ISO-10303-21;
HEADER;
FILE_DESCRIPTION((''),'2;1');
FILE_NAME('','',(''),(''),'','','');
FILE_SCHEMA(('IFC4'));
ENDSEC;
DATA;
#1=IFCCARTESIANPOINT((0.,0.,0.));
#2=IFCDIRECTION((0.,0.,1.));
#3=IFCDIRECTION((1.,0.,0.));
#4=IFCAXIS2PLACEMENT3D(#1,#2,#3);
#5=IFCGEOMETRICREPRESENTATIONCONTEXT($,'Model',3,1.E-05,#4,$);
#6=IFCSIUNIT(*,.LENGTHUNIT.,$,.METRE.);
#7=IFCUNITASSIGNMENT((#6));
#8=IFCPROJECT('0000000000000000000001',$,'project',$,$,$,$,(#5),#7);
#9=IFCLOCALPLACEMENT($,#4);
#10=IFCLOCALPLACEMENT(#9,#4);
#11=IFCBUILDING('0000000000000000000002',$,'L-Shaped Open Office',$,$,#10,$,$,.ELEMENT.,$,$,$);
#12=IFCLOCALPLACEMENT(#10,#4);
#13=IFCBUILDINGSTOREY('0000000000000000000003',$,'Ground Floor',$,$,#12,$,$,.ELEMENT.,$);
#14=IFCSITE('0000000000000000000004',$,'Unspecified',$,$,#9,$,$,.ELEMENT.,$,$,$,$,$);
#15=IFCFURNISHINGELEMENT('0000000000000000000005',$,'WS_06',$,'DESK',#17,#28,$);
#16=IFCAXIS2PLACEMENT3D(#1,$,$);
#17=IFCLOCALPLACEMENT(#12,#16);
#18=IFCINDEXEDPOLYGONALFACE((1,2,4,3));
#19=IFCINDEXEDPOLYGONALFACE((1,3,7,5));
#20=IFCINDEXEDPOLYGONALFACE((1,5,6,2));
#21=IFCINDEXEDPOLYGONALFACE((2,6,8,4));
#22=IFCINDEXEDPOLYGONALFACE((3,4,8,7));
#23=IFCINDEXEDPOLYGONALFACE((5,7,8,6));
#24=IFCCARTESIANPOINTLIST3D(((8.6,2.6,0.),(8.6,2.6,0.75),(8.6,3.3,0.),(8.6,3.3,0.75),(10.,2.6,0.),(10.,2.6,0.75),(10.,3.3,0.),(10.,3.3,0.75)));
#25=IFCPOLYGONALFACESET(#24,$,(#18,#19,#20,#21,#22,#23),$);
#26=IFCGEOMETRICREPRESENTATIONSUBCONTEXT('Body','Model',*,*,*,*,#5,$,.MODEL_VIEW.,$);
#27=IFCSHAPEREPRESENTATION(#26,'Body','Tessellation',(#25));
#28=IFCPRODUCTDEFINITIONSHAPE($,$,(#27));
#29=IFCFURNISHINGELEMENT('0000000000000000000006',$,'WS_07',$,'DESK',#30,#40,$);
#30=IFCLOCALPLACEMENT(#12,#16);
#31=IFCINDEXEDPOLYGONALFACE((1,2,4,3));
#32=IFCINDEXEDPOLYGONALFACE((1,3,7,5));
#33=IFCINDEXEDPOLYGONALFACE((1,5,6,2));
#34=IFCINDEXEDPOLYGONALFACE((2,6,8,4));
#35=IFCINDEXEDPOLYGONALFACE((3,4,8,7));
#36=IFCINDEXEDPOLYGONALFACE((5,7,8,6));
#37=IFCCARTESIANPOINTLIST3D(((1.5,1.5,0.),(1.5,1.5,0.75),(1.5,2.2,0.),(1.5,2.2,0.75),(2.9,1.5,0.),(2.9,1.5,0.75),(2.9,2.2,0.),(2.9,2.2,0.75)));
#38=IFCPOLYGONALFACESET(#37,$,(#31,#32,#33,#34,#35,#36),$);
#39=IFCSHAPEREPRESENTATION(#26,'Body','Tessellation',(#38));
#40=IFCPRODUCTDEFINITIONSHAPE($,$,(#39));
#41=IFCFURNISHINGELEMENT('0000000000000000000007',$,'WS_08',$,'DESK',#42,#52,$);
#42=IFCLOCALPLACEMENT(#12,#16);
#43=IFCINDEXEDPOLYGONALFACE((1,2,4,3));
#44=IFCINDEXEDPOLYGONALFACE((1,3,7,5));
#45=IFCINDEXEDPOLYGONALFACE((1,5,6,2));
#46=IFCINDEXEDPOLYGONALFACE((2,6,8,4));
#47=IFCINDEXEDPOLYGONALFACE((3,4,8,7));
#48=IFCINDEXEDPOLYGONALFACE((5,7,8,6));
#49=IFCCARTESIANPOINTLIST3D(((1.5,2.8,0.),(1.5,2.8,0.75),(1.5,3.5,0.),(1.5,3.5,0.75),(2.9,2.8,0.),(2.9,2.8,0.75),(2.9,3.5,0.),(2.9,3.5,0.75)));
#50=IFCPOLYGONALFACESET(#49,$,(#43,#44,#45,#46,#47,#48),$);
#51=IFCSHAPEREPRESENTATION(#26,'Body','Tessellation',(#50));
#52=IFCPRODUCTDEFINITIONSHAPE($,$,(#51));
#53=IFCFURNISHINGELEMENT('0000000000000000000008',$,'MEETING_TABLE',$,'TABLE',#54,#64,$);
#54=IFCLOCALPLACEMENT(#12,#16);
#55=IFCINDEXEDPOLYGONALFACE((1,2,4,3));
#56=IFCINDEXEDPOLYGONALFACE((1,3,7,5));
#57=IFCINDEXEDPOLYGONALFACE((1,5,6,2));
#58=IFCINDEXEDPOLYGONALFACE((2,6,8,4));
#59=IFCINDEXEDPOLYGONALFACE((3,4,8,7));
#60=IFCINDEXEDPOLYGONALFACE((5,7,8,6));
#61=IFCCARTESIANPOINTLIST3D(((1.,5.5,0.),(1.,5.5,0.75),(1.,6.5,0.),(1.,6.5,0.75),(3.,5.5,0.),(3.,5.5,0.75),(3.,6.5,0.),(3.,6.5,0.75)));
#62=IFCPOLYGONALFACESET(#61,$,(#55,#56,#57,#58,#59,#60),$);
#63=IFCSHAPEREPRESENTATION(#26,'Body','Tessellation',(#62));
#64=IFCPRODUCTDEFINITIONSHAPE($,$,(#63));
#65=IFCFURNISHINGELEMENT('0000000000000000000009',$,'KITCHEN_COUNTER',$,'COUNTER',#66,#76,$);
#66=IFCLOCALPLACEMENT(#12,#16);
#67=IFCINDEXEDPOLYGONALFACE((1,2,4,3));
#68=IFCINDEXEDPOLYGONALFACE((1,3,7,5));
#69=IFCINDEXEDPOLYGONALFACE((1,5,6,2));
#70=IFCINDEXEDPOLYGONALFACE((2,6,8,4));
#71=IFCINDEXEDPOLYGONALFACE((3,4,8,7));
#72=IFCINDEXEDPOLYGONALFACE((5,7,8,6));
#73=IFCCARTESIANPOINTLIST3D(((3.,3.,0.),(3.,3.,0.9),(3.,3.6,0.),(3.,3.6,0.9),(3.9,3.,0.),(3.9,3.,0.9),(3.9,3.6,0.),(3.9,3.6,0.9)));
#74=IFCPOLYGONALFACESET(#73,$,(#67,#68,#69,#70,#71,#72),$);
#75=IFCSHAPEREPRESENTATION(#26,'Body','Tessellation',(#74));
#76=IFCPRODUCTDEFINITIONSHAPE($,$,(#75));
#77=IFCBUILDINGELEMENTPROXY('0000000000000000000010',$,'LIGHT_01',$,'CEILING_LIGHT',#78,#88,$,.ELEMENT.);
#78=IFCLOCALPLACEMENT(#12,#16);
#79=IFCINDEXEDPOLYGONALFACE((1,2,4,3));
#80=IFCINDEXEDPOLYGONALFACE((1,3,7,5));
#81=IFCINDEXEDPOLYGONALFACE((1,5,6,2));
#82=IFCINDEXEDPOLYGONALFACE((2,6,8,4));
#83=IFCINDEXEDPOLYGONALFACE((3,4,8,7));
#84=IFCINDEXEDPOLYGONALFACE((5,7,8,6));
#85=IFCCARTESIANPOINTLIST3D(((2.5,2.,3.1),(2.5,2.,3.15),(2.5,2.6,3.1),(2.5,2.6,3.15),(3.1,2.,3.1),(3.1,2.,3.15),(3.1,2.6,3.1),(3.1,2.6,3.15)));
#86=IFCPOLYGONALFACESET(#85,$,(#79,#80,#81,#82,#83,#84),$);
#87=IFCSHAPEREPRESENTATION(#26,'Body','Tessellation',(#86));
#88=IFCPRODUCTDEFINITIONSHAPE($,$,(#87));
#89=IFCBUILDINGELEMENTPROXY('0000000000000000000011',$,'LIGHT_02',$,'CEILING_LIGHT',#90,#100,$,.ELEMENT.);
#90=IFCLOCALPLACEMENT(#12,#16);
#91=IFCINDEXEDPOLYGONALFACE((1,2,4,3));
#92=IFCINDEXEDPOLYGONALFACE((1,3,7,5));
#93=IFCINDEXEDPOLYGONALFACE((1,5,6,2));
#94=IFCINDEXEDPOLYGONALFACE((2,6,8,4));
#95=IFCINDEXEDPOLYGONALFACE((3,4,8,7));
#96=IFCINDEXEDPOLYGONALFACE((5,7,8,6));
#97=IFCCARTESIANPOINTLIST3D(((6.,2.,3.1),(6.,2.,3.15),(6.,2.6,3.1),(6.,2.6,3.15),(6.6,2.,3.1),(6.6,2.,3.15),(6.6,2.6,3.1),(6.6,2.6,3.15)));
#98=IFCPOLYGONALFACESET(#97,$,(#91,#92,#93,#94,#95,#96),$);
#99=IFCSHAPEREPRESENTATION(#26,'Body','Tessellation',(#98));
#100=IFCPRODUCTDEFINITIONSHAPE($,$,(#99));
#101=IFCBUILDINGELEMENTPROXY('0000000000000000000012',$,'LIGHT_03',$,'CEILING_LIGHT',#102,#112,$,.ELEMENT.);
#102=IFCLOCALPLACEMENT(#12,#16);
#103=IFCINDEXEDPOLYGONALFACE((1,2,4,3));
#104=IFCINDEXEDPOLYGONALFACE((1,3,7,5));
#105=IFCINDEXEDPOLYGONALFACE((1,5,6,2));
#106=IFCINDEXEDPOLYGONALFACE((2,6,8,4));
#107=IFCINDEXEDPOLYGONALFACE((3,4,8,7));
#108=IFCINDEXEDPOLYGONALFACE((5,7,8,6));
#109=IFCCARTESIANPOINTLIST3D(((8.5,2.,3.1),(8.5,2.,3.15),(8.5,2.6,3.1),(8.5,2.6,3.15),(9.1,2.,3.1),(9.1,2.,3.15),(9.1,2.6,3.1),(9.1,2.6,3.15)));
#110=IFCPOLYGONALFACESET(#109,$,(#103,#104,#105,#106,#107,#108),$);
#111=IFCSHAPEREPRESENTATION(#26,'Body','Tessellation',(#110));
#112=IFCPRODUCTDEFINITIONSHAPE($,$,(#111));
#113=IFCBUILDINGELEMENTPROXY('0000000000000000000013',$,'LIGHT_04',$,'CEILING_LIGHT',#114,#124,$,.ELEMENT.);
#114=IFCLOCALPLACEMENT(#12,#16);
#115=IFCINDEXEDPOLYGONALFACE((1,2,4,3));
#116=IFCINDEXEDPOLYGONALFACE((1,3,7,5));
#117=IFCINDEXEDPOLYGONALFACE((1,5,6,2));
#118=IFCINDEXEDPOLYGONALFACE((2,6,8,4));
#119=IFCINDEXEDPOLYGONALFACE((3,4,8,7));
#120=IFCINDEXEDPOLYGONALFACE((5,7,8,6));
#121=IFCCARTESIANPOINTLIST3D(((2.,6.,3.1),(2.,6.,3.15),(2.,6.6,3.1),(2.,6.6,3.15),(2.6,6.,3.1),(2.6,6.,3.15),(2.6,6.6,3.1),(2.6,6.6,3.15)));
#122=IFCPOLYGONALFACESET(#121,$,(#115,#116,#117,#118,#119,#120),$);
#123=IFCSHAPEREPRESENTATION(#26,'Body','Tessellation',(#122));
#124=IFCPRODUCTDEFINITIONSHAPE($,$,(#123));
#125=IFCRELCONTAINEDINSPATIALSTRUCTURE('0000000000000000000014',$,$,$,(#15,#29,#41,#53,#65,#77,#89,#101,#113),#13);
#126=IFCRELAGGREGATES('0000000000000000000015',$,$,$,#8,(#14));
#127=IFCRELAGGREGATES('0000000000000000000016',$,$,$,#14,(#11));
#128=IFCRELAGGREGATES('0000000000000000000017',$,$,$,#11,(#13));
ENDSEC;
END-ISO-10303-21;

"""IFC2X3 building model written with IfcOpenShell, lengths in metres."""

from ifc_helpers import new_model, si_unit, frame, frame_2d, origin, origin_with_axes, place, context, subcontext, project, spatial, rectangle, extrude, element, save


model = new_model("IFC2X3")

# Units and contexts
model_context = context("Model", 3, precision=1e-05, world=origin_with_axes())
body_context = subcontext(model_context, "Body", "Model", "MODEL_VIEW")
ifc_project = project(units=[si_unit("LENGTHUNIT", "METRE")], contexts=[model_context])

# Site, building, storey
site_placement = place(None, origin_with_axes())
site = spatial("IfcSite", under=ifc_project, at=site_placement, Name="Unspecified", CompositionType="ELEMENT")
building_placement = place(site_placement, origin_with_axes())
building = spatial("IfcBuilding", under=site, at=building_placement, Name="L-Shaped Open Office", CompositionType="ELEMENT")
storey_placement = place(building_placement, origin_with_axes())
storey = spatial("IfcBuildingStorey", under=building, at=storey_placement, Name="Ground Floor", CompositionType="ELEMENT")

# Furnishing elements
for number, where, z_axis, x_axis, name in (
    (1, (8.6, 2.6, 0.0), (0.0, 0.0, 1.0), (1.0, 0.0, 0.0), "WS_06"),
    (2, (1.5, 1.5, 0.0), (0.0, 0.0, 1.0), (1.0, 0.0, 0.0), "WS_07"),
    (3, (1.5, 2.8, 0.0), (0.0, 0.0, 1.0), (1.0, 0.0, 0.0), "WS_08"),
):
    element("IfcFurnishingElement", number, at=place(storey_placement, frame(where, z_axis=z_axis, x_axis=x_axis)), inside=storey, Name=name, ObjectType="DESK", context=body_context, shape_type="SweptSolid", body=[
        extrude(rectangle(XDim=1.4, YDim=0.7, at=frame_2d((0.7, 0.35))), origin(), (0.0, 0.0, 1.0), 0.75),
    ])
furnishing_1_placement = place(storey_placement, frame((1.0, 5.5, 0.0), z_axis=(0.0, 0.0, 1.0), x_axis=(1.0, 0.0, 0.0)))
element("IfcFurnishingElement", 4, at=furnishing_1_placement, inside=storey, Name="MEETING_TABLE", ObjectType="TABLE", context=body_context, shape_type="SweptSolid", body=[
    extrude(rectangle(XDim=2.0, YDim=1.0, at=frame_2d((1.0, 0.5))), origin(), (0.0, 0.0, 1.0), 0.75),
])
furnishing_2_placement = place(storey_placement, frame((3.0, 3.0, 0.0), z_axis=(0.0, 0.0, 1.0), x_axis=(1.0, 0.0, 0.0)))
element("IfcFurnishingElement", 5, at=furnishing_2_placement, inside=storey, Name="KITCHEN_COUNTER", ObjectType="COUNTER", context=body_context, shape_type="SweptSolid", body=[
    extrude(rectangle(XDim=0.9, YDim=0.6, at=frame_2d((0.45, 0.3))), origin(), (0.0, 0.0, 1.0), 0.9),
])

# Building element proxies
for number, where, z_axis, x_axis, name in (
    (6, (2.5, 2.0, 3.1), (0.0, 0.0, 1.0), (1.0, 0.0, 0.0), "LIGHT_01"),
    (7, (6.0, 2.0, 3.1), (0.0, 0.0, 1.0), (1.0, 0.0, 0.0), "LIGHT_02"),
    (8, (8.5, 2.0, 3.1), (0.0, 0.0, 1.0), (1.0, 0.0, 0.0), "LIGHT_03"),
    (9, (2.0, 6.0, 3.1), (0.0, 0.0, 1.0), (1.0, 0.0, 0.0), "LIGHT_04"),
):
    element("IfcBuildingElementProxy", number, at=place(storey_placement, frame(where, z_axis=z_axis, x_axis=x_axis)), inside=storey, Name=name, ObjectType="CEILING_LIGHT", CompositionType="ELEMENT", context=body_context, shape_type="SweptSolid", body=[
        extrude(rectangle(XDim=0.6, YDim=0.6, at=frame_2d((0.3, 0.3))), origin(), (0.0, 0.0, 1.0), 0.05),
    ])

save(model, "model.ifc")
